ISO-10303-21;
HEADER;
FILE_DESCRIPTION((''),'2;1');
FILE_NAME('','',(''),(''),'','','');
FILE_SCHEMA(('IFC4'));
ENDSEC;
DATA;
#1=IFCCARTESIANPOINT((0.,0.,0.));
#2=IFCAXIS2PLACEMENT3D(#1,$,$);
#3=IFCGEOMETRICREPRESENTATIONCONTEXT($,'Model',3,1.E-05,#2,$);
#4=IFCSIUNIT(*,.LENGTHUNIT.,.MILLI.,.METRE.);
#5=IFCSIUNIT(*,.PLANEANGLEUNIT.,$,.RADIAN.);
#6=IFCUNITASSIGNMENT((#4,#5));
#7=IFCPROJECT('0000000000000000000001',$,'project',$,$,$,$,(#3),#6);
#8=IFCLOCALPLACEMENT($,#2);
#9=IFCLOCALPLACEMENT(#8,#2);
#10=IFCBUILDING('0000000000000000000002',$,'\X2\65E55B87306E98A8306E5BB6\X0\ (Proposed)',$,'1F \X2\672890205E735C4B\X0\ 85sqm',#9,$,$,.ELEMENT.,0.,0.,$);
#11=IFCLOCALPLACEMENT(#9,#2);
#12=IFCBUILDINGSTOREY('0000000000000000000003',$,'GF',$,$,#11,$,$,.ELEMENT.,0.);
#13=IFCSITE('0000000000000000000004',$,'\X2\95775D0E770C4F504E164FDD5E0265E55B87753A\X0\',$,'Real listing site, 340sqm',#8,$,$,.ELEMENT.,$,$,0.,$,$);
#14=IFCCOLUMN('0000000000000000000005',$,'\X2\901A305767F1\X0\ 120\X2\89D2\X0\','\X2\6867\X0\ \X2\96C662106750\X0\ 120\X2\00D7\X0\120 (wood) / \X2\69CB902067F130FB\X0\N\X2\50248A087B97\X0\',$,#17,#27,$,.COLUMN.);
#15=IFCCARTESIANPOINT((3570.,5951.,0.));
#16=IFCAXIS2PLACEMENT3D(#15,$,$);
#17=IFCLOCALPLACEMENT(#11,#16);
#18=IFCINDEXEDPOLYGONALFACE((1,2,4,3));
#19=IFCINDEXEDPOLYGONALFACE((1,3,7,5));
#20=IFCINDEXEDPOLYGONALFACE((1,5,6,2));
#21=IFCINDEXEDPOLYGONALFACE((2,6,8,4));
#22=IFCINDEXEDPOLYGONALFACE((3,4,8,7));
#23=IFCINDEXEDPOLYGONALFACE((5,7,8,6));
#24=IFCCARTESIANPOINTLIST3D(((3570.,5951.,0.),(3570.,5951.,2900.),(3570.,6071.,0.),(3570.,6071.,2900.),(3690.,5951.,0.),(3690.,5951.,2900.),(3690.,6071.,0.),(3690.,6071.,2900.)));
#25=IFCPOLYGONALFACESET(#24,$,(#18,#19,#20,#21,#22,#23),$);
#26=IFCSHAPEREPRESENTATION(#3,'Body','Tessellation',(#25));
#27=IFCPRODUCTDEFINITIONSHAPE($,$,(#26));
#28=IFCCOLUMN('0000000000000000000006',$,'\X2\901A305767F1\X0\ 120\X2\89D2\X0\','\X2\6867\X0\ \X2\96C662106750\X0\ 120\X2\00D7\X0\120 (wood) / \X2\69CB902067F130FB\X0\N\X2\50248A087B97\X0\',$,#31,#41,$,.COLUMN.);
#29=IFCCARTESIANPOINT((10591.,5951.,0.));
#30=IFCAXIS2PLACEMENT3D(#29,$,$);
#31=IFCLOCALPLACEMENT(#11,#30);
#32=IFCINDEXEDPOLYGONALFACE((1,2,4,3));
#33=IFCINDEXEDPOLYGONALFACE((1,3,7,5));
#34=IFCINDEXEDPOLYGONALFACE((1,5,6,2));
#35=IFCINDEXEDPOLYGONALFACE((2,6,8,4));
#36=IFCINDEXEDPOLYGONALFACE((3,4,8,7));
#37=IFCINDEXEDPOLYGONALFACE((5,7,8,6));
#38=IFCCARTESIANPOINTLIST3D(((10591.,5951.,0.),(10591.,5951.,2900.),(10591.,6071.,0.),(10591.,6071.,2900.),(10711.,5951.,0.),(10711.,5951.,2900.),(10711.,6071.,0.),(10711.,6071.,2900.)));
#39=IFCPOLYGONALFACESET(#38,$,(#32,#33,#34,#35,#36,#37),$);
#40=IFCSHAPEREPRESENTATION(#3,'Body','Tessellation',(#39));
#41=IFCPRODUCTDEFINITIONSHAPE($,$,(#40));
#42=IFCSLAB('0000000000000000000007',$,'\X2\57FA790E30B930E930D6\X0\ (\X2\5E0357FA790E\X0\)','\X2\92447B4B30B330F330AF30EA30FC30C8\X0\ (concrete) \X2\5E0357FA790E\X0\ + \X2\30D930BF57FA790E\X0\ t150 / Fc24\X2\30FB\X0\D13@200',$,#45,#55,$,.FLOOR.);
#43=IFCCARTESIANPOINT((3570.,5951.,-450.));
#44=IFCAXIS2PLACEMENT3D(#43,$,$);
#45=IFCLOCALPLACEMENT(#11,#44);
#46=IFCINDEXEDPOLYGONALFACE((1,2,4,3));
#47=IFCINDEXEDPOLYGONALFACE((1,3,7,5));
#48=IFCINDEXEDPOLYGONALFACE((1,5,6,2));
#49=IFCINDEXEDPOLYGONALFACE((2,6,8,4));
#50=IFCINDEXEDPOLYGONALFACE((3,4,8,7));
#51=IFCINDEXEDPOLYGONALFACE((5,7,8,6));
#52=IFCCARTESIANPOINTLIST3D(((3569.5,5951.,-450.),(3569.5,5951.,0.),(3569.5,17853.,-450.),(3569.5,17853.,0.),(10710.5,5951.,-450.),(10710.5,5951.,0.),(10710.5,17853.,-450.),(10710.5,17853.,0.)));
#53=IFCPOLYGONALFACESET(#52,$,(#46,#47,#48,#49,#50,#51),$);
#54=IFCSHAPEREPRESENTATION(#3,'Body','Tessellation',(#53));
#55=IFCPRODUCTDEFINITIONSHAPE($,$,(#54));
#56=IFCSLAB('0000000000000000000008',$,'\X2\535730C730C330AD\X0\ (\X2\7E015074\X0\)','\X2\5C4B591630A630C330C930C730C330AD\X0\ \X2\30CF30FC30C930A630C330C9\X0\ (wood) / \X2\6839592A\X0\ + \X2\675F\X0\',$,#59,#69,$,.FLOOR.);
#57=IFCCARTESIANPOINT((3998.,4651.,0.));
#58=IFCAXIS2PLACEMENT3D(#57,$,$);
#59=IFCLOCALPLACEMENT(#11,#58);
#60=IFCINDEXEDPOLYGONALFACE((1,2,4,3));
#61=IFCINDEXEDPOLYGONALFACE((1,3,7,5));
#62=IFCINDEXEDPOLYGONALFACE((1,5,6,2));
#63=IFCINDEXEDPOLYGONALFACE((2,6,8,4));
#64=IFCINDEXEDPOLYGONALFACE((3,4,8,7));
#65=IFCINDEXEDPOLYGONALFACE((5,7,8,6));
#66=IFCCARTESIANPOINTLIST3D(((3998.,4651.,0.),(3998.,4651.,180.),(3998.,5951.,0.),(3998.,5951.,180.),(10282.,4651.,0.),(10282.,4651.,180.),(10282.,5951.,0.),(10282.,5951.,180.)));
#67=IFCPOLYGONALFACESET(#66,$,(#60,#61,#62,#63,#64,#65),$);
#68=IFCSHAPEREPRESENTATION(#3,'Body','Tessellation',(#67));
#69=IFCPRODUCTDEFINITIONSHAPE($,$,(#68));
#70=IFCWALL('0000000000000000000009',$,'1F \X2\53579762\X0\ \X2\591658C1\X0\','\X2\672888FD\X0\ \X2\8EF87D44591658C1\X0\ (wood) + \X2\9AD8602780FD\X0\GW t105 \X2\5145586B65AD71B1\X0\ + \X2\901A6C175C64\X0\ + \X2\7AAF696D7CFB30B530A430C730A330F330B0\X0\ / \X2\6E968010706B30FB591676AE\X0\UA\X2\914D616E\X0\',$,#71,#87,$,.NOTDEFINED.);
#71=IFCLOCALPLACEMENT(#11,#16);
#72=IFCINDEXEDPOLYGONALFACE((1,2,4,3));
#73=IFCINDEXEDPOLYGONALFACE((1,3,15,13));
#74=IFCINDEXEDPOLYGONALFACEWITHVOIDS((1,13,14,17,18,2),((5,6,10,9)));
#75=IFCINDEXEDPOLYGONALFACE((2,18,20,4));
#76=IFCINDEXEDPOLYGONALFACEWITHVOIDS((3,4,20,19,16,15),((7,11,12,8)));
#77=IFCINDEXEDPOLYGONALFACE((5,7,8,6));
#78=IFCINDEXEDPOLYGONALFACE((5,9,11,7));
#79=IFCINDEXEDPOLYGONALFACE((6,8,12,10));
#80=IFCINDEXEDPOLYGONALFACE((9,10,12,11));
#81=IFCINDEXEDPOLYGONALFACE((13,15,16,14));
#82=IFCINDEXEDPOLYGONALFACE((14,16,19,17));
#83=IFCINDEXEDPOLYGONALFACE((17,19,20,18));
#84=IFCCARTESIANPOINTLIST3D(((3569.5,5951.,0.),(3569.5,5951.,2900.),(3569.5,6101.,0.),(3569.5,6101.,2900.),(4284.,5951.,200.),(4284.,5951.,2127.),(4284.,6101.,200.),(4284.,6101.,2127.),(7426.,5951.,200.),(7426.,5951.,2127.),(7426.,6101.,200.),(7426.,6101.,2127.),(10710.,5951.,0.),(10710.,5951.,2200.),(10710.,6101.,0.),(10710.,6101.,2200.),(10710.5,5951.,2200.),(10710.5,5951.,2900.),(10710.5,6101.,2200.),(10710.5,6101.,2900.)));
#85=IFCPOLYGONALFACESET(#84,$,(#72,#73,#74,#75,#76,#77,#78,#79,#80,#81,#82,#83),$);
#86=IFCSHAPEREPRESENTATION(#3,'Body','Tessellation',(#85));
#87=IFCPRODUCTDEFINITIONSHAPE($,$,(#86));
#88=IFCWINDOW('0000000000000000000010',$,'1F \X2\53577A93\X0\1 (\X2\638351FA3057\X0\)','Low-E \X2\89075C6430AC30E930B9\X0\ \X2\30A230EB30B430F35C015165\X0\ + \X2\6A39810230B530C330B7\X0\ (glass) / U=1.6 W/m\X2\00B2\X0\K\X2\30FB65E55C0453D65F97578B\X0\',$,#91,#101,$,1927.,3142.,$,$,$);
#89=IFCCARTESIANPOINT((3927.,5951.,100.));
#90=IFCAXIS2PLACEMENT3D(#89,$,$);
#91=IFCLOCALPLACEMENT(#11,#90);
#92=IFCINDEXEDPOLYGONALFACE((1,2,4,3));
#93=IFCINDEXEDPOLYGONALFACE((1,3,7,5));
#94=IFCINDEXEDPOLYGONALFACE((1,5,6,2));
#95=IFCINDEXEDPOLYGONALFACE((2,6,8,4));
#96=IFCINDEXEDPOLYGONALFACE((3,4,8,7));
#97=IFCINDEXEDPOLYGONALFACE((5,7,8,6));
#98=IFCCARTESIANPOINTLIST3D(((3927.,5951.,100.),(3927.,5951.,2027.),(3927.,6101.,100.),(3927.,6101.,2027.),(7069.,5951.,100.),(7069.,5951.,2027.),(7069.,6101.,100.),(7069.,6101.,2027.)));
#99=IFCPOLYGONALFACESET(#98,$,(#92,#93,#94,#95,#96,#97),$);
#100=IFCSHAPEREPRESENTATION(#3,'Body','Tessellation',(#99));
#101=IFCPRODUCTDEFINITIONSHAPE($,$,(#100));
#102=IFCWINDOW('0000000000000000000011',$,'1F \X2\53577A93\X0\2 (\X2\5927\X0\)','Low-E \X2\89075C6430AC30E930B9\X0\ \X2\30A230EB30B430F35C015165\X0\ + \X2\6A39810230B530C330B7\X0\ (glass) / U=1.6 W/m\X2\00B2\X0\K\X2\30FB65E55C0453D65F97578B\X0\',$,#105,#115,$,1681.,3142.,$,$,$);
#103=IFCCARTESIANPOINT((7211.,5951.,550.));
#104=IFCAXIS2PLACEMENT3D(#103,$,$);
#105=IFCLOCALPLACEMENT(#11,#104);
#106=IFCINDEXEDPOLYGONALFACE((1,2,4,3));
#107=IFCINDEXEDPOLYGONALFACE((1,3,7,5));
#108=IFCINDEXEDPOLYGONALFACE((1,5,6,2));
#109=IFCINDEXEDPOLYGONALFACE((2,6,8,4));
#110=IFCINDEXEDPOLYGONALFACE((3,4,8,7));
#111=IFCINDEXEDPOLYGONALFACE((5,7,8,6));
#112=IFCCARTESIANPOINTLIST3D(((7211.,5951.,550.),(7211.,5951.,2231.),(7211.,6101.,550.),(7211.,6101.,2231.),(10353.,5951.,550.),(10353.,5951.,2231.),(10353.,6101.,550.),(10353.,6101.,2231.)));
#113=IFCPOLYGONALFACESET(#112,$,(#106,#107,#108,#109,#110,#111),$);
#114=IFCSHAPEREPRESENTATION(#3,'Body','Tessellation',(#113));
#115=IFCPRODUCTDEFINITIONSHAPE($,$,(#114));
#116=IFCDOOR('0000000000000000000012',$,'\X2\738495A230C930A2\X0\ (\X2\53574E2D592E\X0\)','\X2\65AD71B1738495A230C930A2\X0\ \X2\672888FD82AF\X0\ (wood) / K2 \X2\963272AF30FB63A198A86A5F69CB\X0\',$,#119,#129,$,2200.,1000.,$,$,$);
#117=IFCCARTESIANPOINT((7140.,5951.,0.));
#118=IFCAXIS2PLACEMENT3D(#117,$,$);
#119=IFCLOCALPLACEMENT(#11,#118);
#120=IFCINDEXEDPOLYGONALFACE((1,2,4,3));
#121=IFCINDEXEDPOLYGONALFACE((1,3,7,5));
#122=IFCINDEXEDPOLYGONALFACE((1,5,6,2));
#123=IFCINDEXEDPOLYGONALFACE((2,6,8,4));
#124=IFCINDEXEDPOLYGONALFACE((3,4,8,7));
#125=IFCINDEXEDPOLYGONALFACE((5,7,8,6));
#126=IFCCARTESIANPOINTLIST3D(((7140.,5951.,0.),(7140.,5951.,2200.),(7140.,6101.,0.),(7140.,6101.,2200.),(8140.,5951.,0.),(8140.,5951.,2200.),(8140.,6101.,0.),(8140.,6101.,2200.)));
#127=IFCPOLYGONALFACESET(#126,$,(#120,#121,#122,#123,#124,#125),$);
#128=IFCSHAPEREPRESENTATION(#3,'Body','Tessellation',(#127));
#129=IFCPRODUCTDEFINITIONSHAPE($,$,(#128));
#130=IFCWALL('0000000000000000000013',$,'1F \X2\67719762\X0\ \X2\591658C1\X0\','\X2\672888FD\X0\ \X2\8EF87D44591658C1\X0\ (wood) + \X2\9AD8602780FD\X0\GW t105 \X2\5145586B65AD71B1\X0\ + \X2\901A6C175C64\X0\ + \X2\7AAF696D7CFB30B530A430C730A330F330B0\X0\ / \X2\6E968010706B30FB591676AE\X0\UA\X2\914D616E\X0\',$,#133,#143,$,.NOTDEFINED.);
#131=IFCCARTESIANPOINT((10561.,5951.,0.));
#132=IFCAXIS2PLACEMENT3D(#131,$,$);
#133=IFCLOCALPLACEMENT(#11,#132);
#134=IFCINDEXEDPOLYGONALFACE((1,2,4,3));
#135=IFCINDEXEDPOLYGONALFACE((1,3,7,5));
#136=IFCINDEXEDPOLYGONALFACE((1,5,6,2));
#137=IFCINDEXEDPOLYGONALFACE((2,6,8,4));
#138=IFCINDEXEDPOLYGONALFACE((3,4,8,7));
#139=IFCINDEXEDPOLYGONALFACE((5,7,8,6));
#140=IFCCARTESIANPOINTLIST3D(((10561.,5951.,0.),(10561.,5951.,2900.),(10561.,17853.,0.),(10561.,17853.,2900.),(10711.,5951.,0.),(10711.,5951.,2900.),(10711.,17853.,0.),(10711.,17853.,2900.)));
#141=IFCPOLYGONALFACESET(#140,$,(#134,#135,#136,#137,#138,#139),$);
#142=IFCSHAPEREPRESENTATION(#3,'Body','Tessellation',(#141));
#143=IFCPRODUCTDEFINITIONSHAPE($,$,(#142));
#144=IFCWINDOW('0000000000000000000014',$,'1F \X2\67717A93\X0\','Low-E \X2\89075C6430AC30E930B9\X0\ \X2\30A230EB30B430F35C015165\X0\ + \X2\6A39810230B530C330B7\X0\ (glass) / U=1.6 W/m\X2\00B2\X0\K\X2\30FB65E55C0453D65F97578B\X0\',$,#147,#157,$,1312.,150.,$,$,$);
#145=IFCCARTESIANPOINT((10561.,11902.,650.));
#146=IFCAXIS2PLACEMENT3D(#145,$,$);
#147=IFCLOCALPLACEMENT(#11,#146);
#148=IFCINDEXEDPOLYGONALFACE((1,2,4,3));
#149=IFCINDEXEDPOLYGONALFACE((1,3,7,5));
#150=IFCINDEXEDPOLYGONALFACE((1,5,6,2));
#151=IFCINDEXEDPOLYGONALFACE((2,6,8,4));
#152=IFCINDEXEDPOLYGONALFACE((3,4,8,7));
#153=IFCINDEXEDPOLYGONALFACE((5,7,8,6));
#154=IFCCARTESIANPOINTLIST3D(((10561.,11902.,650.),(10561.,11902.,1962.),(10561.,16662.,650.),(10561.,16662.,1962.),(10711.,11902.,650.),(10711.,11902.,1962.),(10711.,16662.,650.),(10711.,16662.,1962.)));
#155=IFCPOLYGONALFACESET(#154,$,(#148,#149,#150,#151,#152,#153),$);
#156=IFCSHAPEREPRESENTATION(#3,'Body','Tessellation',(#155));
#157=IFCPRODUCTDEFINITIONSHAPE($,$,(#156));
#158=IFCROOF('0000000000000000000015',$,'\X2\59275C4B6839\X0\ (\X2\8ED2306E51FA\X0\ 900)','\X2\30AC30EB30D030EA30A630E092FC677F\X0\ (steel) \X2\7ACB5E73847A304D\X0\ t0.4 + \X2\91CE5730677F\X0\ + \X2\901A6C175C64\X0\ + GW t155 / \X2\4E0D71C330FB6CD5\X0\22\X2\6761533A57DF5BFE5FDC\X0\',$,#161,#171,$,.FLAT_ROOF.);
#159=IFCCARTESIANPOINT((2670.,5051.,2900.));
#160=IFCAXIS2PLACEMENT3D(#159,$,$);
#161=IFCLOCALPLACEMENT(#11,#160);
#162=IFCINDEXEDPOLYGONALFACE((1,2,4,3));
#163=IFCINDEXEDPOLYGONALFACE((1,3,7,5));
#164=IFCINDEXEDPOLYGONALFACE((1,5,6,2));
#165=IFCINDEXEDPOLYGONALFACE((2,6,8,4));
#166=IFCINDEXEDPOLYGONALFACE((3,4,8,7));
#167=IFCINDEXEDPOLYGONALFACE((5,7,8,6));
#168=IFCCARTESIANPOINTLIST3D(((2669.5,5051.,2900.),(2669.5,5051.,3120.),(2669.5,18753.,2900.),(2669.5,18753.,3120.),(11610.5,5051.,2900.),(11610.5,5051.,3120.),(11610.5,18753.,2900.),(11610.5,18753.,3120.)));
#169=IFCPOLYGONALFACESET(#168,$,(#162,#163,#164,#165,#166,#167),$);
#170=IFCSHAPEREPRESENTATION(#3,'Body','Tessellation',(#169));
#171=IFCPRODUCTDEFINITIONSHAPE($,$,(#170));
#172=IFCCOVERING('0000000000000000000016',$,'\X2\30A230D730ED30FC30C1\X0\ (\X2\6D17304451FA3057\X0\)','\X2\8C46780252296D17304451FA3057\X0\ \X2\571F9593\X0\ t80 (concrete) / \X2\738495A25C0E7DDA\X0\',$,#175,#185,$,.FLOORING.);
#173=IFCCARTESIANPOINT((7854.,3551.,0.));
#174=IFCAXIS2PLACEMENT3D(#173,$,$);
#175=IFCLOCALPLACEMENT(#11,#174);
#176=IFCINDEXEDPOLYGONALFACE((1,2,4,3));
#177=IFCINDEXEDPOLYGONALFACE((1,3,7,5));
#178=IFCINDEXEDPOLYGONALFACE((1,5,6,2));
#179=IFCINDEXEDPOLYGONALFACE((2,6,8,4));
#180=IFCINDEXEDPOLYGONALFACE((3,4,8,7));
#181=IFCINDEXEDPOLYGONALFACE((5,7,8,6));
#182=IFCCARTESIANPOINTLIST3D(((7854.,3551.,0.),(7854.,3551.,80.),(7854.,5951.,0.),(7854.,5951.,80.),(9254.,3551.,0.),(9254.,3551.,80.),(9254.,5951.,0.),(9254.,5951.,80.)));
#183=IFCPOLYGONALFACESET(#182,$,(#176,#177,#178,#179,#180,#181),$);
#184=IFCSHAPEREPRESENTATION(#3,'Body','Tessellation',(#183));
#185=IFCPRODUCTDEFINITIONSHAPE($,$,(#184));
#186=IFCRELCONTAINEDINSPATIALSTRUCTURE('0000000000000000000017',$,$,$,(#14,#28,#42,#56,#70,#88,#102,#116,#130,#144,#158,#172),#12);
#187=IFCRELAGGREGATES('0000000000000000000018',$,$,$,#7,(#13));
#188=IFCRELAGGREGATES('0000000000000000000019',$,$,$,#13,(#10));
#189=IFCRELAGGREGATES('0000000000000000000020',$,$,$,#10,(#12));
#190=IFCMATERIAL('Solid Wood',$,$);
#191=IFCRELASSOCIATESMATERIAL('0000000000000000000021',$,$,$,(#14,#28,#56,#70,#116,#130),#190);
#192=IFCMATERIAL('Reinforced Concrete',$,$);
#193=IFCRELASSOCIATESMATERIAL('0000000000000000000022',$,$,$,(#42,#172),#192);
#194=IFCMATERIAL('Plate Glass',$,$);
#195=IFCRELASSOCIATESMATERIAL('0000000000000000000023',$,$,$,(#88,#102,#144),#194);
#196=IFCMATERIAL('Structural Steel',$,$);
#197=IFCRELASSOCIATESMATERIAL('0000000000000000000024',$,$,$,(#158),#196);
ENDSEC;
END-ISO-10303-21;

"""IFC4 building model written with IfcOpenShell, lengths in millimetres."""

from ifc_helpers import new_model, si_unit, frame, frame_2d, origin, place, context, project, spatial, rectangle, extrude, material, element, fill, save


model = new_model("IFC4")

# Units and contexts
model_context = context("Model", 3, precision=1e-05, world=origin())
ifc_project = project(units=[si_unit("LENGTHUNIT", "METRE", prefix="MILLI"), si_unit("PLANEANGLEUNIT", "RADIAN")], contexts=[model_context])

# Site, building, storey
site_placement = place(None, origin())
site = spatial("IfcSite", under=ifc_project, at=site_placement, Name="長崎県佐世保市日宇町", ObjectType="Real listing site, 340sqm", CompositionType="ELEMENT", RefElevation=0.0)
building_placement = place(site_placement, origin())
building = spatial("IfcBuilding", under=site, at=building_placement, Name="日宇の風の家 (Proposed)", ObjectType="1F 木造平屋 85sqm", CompositionType="ELEMENT", ElevationOfRefHeight=0.0, ElevationOfTerrain=0.0)
storey_placement = place(building_placement, origin())
storey = spatial("IfcBuildingStorey", under=building, at=storey_placement, Name="GF", CompositionType="ELEMENT", Elevation=0.0)

# Columns
ifc_material_1 = material(Name="Solid Wood")
column_1_placement = place(storey_placement, frame((3570.0, 5951.0, 0.0)))
element("IfcColumn", 1, at=column_1_placement, inside=storey, material=ifc_material_1, Name="通し柱 120角", Description="桧 集成材 120×120 (wood) / 構造柱・N値計算", PredefinedType="COLUMN", context=model_context, shape_type="SweptSolid", body=[
    extrude(rectangle(XDim=120.0, YDim=120.0, at=frame_2d((60.0, 60.0))), frame((3570.0, 5951.0, 0.0)), (0.0, 0.0, 1.0), 2900.0),
])
column_2_placement = place(storey_placement, frame((10591.0, 5951.0, 0.0)))
element("IfcColumn", 2, at=column_2_placement, inside=storey, material=ifc_material_1, Name="通し柱 120角", Description="桧 集成材 120×120 (wood) / 構造柱・N値計算", PredefinedType="COLUMN", context=model_context, shape_type="SweptSolid", body=[
    extrude(rectangle(XDim=120.0, YDim=120.0, at=frame_2d((60.0, 60.0))), frame((10591.0, 5951.0, 0.0)), (0.0, 0.0, 1.0), 2900.0),
])

# Slabs
ifc_material_2 = material(Name="Reinforced Concrete")
slab_1_placement = place(storey_placement, frame((3570.0, 5951.0, -450.0)))
element("IfcSlab", 3, at=slab_1_placement, inside=storey, material=ifc_material_2, Name="基礎スラブ (布基礎)", Description="鉄筋コンクリート (concrete) 布基礎 + ベタ基礎 t150 / Fc24・D13@200", PredefinedType="FLOOR", context=model_context, shape_type="SweptSolid", body=[
    extrude(rectangle(XDim=7141.0, YDim=11902.0, at=frame_2d((3570.0, 5951.0))), frame((3570.0, 5951.0, -450.0)), (0.0, 0.0, 1.0), 450.0),
])
slab_2_placement = place(storey_placement, frame((3998.0, 4651.0, 0.0)))
element("IfcSlab", 4, at=slab_2_placement, inside=storey, material=ifc_material_1, Name="南デッキ (縁側)", Description="屋外ウッドデッキ ハードウッド (wood) / 根太 + 束", PredefinedType="FLOOR", context=model_context, shape_type="SweptSolid", body=[
    extrude(rectangle(XDim=6284.0, YDim=1300.0, at=frame_2d((3142.0, 650.0))), frame((3998.0, 4651.0, 0.0)), (0.0, 0.0, 1.0), 180.0),
])

# Wall, openings, windows, door
wall_1_placement = place(storey_placement, frame((3570.0, 5951.0, 0.0)))
wall_1 = element("IfcWall", 5, at=wall_1_placement, inside=storey, material=ifc_material_1, Name="1F 南面 外壁", Description="木製 軸組外壁 (wood) + 高性能GW t105 充填断熱 + 通気層 + 窯業系サイディング / 準耐火・外皮UA配慮", PredefinedType="NOTDEFINED", context=model_context, shape_type="SweptSolid", body=[
    extrude(rectangle(XDim=7141.0, YDim=150.0, at=frame_2d((3570.0, 75.0))), frame((3570.0, 5951.0, 0.0)), (0.0, 0.0, 1.0), 2900.0),
])
opening_1_placement = place(storey_placement, frame((3927.0, 5951.0, 100.0)))
opening_1 = element("IfcOpeningElement", 6, at=opening_1_placement, cuts=wall_1, PredefinedType="NOTDEFINED", context=model_context, shape_type="SweptSolid", body=[
    extrude(rectangle(XDim=3142.0, YDim=150.0, at=frame_2d((1571.0, 75.0))), frame((3927.0, 5951.0, 100.0)), (0.0, 0.0, 1.0), 1927.0),
])
opening_2_placement = place(storey_placement, frame((7211.0, 5951.0, 550.0)))
opening_2 = element("IfcOpeningElement", 7, at=opening_2_placement, cuts=wall_1, PredefinedType="NOTDEFINED", context=model_context, shape_type="SweptSolid", body=[
    extrude(rectangle(XDim=3142.0, YDim=150.0, at=frame_2d((1571.0, 75.0))), frame((7211.0, 5951.0, 550.0)), (0.0, 0.0, 1.0), 1681.0),
])
opening_3_placement = place(storey_placement, frame((7140.0, 5951.0, 0.0)))
opening_3 = element("IfcOpeningElement", 8, at=opening_3_placement, cuts=wall_1, PredefinedType="NOTDEFINED", context=model_context, shape_type="SweptSolid", body=[
    extrude(rectangle(XDim=1000.0, YDim=150.0, at=frame_2d((500.0, 75.0))), frame((7140.0, 5951.0, 0.0)), (0.0, 0.0, 1.0), 2200.0),
])
ifc_material_3 = material(Name="Plate Glass")
window_1_placement = place(storey_placement, frame((3927.0, 5951.0, 100.0)))
window_1 = element("IfcWindow", 9, at=window_1_placement, inside=storey, material=ifc_material_3, Name="1F 南窓1 (掃出し)", Description="Low-E 複層ガラス アルゴン封入 + 樹脂サッシ (glass) / U=1.6 W/m²K・日射取得型", OverallHeight=1927.0, OverallWidth=3142.0, context=model_context, shape_type="SweptSolid", body=[
    extrude(rectangle(XDim=3142.0, YDim=150.0, at=frame_2d((1571.0, 75.0))), frame((3927.0, 5951.0, 100.0)), (0.0, 0.0, 1.0), 1927.0),
])
fill(opening_1, window_1)
window_2_placement = place(storey_placement, frame((7211.0, 5951.0, 550.0)))
window_2 = element("IfcWindow", 10, at=window_2_placement, inside=storey, material=ifc_material_3, Name="1F 南窓2 (大)", Description="Low-E 複層ガラス アルゴン封入 + 樹脂サッシ (glass) / U=1.6 W/m²K・日射取得型", OverallHeight=1681.0, OverallWidth=3142.0, context=model_context, shape_type="SweptSolid", body=[
    extrude(rectangle(XDim=3142.0, YDim=150.0, at=frame_2d((1571.0, 75.0))), frame((7211.0, 5951.0, 550.0)), (0.0, 0.0, 1.0), 1681.0),
])
fill(opening_2, window_2)
door_placement = place(storey_placement, frame((7140.0, 5951.0, 0.0)))
door = element("IfcDoor", 11, at=door_placement, inside=storey, material=ifc_material_1, Name="玄関ドア (南中央)", Description="断熱玄関ドア 木製芯 (wood) / K2 防犯・採風機構", OverallHeight=2200.0, OverallWidth=1000.0, context=model_context, shape_type="SweptSolid", body=[
    extrude(rectangle(XDim=1000.0, YDim=150.0, at=frame_2d((500.0, 75.0))), frame((7140.0, 5951.0, 0.0)), (0.0, 0.0, 1.0), 2200.0),
])
fill(opening_3, door)

# Wall, opening, window
wall_2_placement = place(storey_placement, frame((10561.0, 5951.0, 0.0)))
wall_2 = element("IfcWall", 12, at=wall_2_placement, inside=storey, material=ifc_material_1, Name="1F 東面 外壁", Description="木製 軸組外壁 (wood) + 高性能GW t105 充填断熱 + 通気層 + 窯業系サイディング / 準耐火・外皮UA配慮", PredefinedType="NOTDEFINED", context=model_context, shape_type="SweptSolid", body=[
    extrude(rectangle(XDim=150.0, YDim=11902.0, at=frame_2d((75.0, 5951.0))), frame((10561.0, 5951.0, 0.0)), (0.0, 0.0, 1.0), 2900.0),
])
opening_4_placement = place(storey_placement, frame((10561.0, 11902.0, 650.0)))
opening_4 = element("IfcOpeningElement", 13, at=opening_4_placement, cuts=wall_2, PredefinedType="NOTDEFINED", context=model_context, shape_type="SweptSolid", body=[
    extrude(rectangle(XDim=150.0, YDim=4760.0, at=frame_2d((75.0, 2380.0))), frame((10561.0, 11902.0, 650.0)), (0.0, 0.0, 1.0), 1312.0),
])
window_3_placement = place(storey_placement, frame((10561.0, 11902.0, 650.0)))
window_3 = element("IfcWindow", 14, at=window_3_placement, inside=storey, material=ifc_material_3, Name="1F 東窓", Description="Low-E 複層ガラス アルゴン封入 + 樹脂サッシ (glass) / U=1.6 W/m²K・日射取得型", OverallHeight=1312.0, OverallWidth=150.0, context=model_context, shape_type="SweptSolid", body=[
    extrude(rectangle(XDim=150.0, YDim=4760.0, at=frame_2d((75.0, 2380.0))), frame((10561.0, 11902.0, 650.0)), (0.0, 0.0, 1.0), 1312.0),
])
fill(opening_4, window_3)

# Roof
ifc_material_4 = material(Name="Structural Steel")
roof_placement = place(storey_placement, frame((2670.0, 5051.0, 2900.0)))
element("IfcRoof", 15, at=roof_placement, inside=storey, material=ifc_material_4, Name="大屋根 (軒の出 900)", Description="ガルバリウム鋼板 (steel) 立平葺き t0.4 + 野地板 + 通気層 + GW t155 / 不燃・法22条区域対応", PredefinedType="FLAT_ROOF", context=model_context, shape_type="SweptSolid", body=[
    extrude(rectangle(XDim=8941.0, YDim=13702.0, at=frame_2d((4470.0, 6851.0))), frame((2670.0, 5051.0, 2900.0)), (0.0, 0.0, 1.0), 220.0),
])

# Covering
covering_1_placement = place(storey_placement, frame((7854.0, 3551.0, 0.0)))
element("IfcCovering", 16, at=covering_1_placement, inside=storey, material=ifc_material_2, Name="アプローチ (洗い出し)", Description="豆砂利洗い出し 土間 t80 (concrete) / 玄関導線", PredefinedType="FLOORING", context=model_context, shape_type="SweptSolid", body=[
    extrude(rectangle(XDim=1400.0, YDim=2400.0, at=frame_2d((700.0, 1200.0))), frame((7854.0, 3551.0, 0.0)), (0.0, 0.0, 1.0), 80.0),
])

save(model, "model.ifc")
